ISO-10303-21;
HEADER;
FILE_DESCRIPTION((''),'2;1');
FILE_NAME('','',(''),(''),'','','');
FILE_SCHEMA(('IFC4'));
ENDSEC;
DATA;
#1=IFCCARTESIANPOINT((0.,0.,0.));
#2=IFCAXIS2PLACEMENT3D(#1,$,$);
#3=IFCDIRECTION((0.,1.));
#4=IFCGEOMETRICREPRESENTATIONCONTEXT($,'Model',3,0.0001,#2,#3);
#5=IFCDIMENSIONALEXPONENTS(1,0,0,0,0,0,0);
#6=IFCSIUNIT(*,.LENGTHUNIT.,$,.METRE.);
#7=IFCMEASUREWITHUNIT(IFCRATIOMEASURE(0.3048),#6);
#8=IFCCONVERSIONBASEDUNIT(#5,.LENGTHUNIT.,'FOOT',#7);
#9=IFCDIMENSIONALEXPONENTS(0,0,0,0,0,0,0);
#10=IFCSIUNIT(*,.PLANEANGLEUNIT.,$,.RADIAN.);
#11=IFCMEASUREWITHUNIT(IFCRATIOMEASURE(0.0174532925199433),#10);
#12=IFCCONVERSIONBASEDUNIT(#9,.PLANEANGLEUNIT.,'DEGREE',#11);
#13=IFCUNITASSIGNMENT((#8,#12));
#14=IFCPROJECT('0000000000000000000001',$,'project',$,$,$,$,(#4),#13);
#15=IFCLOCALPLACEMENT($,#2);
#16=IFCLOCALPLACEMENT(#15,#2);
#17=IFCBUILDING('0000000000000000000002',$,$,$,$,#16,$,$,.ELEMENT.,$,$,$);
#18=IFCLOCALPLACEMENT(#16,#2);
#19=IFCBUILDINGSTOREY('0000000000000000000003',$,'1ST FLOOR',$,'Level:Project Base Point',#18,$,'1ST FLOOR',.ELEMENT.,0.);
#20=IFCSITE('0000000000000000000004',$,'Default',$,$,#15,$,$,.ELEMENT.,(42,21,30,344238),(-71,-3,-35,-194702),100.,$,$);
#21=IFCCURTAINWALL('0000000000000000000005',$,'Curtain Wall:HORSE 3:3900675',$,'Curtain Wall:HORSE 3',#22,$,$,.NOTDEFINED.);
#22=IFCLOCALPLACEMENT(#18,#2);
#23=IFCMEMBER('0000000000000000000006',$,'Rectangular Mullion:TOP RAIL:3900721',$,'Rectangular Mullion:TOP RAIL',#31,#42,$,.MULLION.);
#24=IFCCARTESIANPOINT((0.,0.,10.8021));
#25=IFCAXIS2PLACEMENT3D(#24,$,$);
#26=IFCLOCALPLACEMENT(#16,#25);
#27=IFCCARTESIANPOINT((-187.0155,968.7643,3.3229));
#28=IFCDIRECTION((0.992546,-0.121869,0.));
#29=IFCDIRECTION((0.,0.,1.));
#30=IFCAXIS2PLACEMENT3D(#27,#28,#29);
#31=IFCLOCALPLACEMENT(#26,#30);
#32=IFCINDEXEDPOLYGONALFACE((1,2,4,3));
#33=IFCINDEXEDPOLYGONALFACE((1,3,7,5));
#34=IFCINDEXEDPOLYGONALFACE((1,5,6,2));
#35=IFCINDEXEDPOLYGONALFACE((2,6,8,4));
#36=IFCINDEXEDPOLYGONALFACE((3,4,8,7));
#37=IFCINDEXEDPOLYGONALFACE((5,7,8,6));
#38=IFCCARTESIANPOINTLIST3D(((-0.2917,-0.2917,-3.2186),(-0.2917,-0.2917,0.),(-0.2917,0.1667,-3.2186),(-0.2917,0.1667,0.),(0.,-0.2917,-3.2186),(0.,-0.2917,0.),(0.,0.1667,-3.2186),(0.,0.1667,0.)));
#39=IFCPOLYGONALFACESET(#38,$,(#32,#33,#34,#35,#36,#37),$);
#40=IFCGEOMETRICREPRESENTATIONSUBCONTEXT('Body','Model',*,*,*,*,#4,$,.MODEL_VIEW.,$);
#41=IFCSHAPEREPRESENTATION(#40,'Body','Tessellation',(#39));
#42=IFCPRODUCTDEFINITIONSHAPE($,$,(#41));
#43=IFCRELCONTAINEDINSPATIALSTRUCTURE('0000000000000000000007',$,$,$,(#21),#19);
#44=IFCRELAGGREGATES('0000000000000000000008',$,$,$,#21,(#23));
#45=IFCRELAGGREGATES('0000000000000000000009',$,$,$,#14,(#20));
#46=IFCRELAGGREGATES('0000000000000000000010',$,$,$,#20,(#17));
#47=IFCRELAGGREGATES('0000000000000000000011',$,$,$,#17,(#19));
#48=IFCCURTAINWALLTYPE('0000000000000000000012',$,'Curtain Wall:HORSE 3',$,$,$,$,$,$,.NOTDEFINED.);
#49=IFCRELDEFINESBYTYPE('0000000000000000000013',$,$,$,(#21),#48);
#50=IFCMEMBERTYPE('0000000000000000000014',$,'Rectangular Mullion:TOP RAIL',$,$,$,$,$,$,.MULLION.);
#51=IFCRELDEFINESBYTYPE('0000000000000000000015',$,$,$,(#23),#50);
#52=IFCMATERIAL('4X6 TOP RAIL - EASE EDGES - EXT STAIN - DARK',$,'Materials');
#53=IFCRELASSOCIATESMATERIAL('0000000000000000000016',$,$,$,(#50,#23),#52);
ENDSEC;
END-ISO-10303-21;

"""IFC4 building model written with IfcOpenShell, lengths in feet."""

from ifc_helpers import new_model, entity, si_unit, converted_unit, direction, frame, origin, origin_2d_with_axis, place, context, subcontext, project, spatial, rectangle, extrude, source, transform, mapped, material, material_profile, profile_set, profile_usage, type_object, type_shapes, element, aggregate, save


model = new_model("IFC4")

# Units and contexts
model_context = context("Model", 3, precision=0.0001, world=origin(), true_north=direction((0.0, 1.0)))
body_context = subcontext(model_context, "Body", "Model", "MODEL_VIEW")
ifc_project = project(units=[converted_unit("LENGTHUNIT", "FOOT", entity("IfcRatioMeasure", 0.3048), si_unit("LENGTHUNIT", "METRE"), dimensions=[1, 0, 0, 0, 0, 0, 0]), converted_unit("PLANEANGLEUNIT", "DEGREE", entity("IfcRatioMeasure", 0.0174532925199433), si_unit("PLANEANGLEUNIT", "RADIAN"), dimensions=[0, 0, 0, 0, 0, 0, 0])], contexts=[model_context])

# Site, building, storey
site_placement = place(None, origin())
site = spatial("IfcSite", under=ifc_project, at=site_placement, Name="Default", CompositionType="ELEMENT", RefLatitude=(42, 21, 30, 344238), RefLongitude=(-71, -3, -35, -194702), RefElevation=100.0)
building_placement = place(site_placement, origin())
building = spatial("IfcBuilding", under=site, at=building_placement, CompositionType="ELEMENT")
storey_placement = place(building_placement, origin())
storey = spatial("IfcBuildingStorey", under=building, at=storey_placement, Name="1ST FLOOR", ObjectType="Level:Project Base Point", LongName="1ST FLOOR", CompositionType="ELEMENT", Elevation=0.0)

# Curtain wall, member
curtain_wall_type_1 = type_object("IfcCurtainWallType", Name="Curtain Wall:HORSE 3", PredefinedType="NOTDEFINED")
curtain_wall_1_placement = place(storey_placement, origin())
curtain_wall_1 = element("IfcCurtainWall", 1, at=curtain_wall_1_placement, inside=storey, type_object=curtain_wall_type_1, Name="Curtain Wall:HORSE 3:3900675", ObjectType="Curtain Wall:HORSE 3", PredefinedType="NOTDEFINED")
ifc_material_1 = material(Name="4X6 TOP RAIL - EASE EDGES - EXT STAIN - DARK", Category="Materials")
ifc_material_profile_1 = material_profile(ifc_material_1, rectangle(XDim=0.4583, YDim=0.2917, at=origin_2d_with_axis()), Name="TOP RAIL")
ifc_profile_set_1 = profile_set([ifc_material_profile_1], Name="TOP RAIL")
ifc_profile_usage_1 = profile_usage(ifc_profile_set_1)
member_type_1 = type_object("IfcMemberType", Name="Rectangular Mullion:TOP RAIL", PredefinedType="MULLION", material=ifc_profile_set_1)
shared_shape_1 = source(origin(), body_context, "Body", "SweptSolid", [
    extrude(rectangle(XDim=0.4583, YDim=0.2917, at=origin_2d_with_axis()), frame((-0.1458, -0.0625, -3.2186), z_axis=(0.0, 0.0, 1.0), x_axis=(0.0, -1.0, 0.0)), (0.0, 0.0, 1.0), 3.2186),
])
type_shapes(member_type_1, [shared_shape_1])
placement = place(building_placement, frame((0.0, 0.0, 10.8021)))
member_1_placement = place(placement, frame((-187.0155, 968.7643, 3.3229), z_axis=(0.992546, -0.121869, 0.0), x_axis=(0.0, 0.0, 1.0)))
member_1 = element("IfcMember", 2, at=member_1_placement, type_object=member_type_1, material=ifc_profile_usage_1, Name="Rectangular Mullion:TOP RAIL:3900721", ObjectType="Rectangular Mullion:TOP RAIL", PredefinedType="MULLION", context=body_context, shape_type="MappedRepresentation", body=[
    mapped(shared_shape_1, transform((0.0, 0.0, 0.0), scale=1.0)),
])
aggregate(curtain_wall_1, [member_1])

save(model, "model.ifc")
